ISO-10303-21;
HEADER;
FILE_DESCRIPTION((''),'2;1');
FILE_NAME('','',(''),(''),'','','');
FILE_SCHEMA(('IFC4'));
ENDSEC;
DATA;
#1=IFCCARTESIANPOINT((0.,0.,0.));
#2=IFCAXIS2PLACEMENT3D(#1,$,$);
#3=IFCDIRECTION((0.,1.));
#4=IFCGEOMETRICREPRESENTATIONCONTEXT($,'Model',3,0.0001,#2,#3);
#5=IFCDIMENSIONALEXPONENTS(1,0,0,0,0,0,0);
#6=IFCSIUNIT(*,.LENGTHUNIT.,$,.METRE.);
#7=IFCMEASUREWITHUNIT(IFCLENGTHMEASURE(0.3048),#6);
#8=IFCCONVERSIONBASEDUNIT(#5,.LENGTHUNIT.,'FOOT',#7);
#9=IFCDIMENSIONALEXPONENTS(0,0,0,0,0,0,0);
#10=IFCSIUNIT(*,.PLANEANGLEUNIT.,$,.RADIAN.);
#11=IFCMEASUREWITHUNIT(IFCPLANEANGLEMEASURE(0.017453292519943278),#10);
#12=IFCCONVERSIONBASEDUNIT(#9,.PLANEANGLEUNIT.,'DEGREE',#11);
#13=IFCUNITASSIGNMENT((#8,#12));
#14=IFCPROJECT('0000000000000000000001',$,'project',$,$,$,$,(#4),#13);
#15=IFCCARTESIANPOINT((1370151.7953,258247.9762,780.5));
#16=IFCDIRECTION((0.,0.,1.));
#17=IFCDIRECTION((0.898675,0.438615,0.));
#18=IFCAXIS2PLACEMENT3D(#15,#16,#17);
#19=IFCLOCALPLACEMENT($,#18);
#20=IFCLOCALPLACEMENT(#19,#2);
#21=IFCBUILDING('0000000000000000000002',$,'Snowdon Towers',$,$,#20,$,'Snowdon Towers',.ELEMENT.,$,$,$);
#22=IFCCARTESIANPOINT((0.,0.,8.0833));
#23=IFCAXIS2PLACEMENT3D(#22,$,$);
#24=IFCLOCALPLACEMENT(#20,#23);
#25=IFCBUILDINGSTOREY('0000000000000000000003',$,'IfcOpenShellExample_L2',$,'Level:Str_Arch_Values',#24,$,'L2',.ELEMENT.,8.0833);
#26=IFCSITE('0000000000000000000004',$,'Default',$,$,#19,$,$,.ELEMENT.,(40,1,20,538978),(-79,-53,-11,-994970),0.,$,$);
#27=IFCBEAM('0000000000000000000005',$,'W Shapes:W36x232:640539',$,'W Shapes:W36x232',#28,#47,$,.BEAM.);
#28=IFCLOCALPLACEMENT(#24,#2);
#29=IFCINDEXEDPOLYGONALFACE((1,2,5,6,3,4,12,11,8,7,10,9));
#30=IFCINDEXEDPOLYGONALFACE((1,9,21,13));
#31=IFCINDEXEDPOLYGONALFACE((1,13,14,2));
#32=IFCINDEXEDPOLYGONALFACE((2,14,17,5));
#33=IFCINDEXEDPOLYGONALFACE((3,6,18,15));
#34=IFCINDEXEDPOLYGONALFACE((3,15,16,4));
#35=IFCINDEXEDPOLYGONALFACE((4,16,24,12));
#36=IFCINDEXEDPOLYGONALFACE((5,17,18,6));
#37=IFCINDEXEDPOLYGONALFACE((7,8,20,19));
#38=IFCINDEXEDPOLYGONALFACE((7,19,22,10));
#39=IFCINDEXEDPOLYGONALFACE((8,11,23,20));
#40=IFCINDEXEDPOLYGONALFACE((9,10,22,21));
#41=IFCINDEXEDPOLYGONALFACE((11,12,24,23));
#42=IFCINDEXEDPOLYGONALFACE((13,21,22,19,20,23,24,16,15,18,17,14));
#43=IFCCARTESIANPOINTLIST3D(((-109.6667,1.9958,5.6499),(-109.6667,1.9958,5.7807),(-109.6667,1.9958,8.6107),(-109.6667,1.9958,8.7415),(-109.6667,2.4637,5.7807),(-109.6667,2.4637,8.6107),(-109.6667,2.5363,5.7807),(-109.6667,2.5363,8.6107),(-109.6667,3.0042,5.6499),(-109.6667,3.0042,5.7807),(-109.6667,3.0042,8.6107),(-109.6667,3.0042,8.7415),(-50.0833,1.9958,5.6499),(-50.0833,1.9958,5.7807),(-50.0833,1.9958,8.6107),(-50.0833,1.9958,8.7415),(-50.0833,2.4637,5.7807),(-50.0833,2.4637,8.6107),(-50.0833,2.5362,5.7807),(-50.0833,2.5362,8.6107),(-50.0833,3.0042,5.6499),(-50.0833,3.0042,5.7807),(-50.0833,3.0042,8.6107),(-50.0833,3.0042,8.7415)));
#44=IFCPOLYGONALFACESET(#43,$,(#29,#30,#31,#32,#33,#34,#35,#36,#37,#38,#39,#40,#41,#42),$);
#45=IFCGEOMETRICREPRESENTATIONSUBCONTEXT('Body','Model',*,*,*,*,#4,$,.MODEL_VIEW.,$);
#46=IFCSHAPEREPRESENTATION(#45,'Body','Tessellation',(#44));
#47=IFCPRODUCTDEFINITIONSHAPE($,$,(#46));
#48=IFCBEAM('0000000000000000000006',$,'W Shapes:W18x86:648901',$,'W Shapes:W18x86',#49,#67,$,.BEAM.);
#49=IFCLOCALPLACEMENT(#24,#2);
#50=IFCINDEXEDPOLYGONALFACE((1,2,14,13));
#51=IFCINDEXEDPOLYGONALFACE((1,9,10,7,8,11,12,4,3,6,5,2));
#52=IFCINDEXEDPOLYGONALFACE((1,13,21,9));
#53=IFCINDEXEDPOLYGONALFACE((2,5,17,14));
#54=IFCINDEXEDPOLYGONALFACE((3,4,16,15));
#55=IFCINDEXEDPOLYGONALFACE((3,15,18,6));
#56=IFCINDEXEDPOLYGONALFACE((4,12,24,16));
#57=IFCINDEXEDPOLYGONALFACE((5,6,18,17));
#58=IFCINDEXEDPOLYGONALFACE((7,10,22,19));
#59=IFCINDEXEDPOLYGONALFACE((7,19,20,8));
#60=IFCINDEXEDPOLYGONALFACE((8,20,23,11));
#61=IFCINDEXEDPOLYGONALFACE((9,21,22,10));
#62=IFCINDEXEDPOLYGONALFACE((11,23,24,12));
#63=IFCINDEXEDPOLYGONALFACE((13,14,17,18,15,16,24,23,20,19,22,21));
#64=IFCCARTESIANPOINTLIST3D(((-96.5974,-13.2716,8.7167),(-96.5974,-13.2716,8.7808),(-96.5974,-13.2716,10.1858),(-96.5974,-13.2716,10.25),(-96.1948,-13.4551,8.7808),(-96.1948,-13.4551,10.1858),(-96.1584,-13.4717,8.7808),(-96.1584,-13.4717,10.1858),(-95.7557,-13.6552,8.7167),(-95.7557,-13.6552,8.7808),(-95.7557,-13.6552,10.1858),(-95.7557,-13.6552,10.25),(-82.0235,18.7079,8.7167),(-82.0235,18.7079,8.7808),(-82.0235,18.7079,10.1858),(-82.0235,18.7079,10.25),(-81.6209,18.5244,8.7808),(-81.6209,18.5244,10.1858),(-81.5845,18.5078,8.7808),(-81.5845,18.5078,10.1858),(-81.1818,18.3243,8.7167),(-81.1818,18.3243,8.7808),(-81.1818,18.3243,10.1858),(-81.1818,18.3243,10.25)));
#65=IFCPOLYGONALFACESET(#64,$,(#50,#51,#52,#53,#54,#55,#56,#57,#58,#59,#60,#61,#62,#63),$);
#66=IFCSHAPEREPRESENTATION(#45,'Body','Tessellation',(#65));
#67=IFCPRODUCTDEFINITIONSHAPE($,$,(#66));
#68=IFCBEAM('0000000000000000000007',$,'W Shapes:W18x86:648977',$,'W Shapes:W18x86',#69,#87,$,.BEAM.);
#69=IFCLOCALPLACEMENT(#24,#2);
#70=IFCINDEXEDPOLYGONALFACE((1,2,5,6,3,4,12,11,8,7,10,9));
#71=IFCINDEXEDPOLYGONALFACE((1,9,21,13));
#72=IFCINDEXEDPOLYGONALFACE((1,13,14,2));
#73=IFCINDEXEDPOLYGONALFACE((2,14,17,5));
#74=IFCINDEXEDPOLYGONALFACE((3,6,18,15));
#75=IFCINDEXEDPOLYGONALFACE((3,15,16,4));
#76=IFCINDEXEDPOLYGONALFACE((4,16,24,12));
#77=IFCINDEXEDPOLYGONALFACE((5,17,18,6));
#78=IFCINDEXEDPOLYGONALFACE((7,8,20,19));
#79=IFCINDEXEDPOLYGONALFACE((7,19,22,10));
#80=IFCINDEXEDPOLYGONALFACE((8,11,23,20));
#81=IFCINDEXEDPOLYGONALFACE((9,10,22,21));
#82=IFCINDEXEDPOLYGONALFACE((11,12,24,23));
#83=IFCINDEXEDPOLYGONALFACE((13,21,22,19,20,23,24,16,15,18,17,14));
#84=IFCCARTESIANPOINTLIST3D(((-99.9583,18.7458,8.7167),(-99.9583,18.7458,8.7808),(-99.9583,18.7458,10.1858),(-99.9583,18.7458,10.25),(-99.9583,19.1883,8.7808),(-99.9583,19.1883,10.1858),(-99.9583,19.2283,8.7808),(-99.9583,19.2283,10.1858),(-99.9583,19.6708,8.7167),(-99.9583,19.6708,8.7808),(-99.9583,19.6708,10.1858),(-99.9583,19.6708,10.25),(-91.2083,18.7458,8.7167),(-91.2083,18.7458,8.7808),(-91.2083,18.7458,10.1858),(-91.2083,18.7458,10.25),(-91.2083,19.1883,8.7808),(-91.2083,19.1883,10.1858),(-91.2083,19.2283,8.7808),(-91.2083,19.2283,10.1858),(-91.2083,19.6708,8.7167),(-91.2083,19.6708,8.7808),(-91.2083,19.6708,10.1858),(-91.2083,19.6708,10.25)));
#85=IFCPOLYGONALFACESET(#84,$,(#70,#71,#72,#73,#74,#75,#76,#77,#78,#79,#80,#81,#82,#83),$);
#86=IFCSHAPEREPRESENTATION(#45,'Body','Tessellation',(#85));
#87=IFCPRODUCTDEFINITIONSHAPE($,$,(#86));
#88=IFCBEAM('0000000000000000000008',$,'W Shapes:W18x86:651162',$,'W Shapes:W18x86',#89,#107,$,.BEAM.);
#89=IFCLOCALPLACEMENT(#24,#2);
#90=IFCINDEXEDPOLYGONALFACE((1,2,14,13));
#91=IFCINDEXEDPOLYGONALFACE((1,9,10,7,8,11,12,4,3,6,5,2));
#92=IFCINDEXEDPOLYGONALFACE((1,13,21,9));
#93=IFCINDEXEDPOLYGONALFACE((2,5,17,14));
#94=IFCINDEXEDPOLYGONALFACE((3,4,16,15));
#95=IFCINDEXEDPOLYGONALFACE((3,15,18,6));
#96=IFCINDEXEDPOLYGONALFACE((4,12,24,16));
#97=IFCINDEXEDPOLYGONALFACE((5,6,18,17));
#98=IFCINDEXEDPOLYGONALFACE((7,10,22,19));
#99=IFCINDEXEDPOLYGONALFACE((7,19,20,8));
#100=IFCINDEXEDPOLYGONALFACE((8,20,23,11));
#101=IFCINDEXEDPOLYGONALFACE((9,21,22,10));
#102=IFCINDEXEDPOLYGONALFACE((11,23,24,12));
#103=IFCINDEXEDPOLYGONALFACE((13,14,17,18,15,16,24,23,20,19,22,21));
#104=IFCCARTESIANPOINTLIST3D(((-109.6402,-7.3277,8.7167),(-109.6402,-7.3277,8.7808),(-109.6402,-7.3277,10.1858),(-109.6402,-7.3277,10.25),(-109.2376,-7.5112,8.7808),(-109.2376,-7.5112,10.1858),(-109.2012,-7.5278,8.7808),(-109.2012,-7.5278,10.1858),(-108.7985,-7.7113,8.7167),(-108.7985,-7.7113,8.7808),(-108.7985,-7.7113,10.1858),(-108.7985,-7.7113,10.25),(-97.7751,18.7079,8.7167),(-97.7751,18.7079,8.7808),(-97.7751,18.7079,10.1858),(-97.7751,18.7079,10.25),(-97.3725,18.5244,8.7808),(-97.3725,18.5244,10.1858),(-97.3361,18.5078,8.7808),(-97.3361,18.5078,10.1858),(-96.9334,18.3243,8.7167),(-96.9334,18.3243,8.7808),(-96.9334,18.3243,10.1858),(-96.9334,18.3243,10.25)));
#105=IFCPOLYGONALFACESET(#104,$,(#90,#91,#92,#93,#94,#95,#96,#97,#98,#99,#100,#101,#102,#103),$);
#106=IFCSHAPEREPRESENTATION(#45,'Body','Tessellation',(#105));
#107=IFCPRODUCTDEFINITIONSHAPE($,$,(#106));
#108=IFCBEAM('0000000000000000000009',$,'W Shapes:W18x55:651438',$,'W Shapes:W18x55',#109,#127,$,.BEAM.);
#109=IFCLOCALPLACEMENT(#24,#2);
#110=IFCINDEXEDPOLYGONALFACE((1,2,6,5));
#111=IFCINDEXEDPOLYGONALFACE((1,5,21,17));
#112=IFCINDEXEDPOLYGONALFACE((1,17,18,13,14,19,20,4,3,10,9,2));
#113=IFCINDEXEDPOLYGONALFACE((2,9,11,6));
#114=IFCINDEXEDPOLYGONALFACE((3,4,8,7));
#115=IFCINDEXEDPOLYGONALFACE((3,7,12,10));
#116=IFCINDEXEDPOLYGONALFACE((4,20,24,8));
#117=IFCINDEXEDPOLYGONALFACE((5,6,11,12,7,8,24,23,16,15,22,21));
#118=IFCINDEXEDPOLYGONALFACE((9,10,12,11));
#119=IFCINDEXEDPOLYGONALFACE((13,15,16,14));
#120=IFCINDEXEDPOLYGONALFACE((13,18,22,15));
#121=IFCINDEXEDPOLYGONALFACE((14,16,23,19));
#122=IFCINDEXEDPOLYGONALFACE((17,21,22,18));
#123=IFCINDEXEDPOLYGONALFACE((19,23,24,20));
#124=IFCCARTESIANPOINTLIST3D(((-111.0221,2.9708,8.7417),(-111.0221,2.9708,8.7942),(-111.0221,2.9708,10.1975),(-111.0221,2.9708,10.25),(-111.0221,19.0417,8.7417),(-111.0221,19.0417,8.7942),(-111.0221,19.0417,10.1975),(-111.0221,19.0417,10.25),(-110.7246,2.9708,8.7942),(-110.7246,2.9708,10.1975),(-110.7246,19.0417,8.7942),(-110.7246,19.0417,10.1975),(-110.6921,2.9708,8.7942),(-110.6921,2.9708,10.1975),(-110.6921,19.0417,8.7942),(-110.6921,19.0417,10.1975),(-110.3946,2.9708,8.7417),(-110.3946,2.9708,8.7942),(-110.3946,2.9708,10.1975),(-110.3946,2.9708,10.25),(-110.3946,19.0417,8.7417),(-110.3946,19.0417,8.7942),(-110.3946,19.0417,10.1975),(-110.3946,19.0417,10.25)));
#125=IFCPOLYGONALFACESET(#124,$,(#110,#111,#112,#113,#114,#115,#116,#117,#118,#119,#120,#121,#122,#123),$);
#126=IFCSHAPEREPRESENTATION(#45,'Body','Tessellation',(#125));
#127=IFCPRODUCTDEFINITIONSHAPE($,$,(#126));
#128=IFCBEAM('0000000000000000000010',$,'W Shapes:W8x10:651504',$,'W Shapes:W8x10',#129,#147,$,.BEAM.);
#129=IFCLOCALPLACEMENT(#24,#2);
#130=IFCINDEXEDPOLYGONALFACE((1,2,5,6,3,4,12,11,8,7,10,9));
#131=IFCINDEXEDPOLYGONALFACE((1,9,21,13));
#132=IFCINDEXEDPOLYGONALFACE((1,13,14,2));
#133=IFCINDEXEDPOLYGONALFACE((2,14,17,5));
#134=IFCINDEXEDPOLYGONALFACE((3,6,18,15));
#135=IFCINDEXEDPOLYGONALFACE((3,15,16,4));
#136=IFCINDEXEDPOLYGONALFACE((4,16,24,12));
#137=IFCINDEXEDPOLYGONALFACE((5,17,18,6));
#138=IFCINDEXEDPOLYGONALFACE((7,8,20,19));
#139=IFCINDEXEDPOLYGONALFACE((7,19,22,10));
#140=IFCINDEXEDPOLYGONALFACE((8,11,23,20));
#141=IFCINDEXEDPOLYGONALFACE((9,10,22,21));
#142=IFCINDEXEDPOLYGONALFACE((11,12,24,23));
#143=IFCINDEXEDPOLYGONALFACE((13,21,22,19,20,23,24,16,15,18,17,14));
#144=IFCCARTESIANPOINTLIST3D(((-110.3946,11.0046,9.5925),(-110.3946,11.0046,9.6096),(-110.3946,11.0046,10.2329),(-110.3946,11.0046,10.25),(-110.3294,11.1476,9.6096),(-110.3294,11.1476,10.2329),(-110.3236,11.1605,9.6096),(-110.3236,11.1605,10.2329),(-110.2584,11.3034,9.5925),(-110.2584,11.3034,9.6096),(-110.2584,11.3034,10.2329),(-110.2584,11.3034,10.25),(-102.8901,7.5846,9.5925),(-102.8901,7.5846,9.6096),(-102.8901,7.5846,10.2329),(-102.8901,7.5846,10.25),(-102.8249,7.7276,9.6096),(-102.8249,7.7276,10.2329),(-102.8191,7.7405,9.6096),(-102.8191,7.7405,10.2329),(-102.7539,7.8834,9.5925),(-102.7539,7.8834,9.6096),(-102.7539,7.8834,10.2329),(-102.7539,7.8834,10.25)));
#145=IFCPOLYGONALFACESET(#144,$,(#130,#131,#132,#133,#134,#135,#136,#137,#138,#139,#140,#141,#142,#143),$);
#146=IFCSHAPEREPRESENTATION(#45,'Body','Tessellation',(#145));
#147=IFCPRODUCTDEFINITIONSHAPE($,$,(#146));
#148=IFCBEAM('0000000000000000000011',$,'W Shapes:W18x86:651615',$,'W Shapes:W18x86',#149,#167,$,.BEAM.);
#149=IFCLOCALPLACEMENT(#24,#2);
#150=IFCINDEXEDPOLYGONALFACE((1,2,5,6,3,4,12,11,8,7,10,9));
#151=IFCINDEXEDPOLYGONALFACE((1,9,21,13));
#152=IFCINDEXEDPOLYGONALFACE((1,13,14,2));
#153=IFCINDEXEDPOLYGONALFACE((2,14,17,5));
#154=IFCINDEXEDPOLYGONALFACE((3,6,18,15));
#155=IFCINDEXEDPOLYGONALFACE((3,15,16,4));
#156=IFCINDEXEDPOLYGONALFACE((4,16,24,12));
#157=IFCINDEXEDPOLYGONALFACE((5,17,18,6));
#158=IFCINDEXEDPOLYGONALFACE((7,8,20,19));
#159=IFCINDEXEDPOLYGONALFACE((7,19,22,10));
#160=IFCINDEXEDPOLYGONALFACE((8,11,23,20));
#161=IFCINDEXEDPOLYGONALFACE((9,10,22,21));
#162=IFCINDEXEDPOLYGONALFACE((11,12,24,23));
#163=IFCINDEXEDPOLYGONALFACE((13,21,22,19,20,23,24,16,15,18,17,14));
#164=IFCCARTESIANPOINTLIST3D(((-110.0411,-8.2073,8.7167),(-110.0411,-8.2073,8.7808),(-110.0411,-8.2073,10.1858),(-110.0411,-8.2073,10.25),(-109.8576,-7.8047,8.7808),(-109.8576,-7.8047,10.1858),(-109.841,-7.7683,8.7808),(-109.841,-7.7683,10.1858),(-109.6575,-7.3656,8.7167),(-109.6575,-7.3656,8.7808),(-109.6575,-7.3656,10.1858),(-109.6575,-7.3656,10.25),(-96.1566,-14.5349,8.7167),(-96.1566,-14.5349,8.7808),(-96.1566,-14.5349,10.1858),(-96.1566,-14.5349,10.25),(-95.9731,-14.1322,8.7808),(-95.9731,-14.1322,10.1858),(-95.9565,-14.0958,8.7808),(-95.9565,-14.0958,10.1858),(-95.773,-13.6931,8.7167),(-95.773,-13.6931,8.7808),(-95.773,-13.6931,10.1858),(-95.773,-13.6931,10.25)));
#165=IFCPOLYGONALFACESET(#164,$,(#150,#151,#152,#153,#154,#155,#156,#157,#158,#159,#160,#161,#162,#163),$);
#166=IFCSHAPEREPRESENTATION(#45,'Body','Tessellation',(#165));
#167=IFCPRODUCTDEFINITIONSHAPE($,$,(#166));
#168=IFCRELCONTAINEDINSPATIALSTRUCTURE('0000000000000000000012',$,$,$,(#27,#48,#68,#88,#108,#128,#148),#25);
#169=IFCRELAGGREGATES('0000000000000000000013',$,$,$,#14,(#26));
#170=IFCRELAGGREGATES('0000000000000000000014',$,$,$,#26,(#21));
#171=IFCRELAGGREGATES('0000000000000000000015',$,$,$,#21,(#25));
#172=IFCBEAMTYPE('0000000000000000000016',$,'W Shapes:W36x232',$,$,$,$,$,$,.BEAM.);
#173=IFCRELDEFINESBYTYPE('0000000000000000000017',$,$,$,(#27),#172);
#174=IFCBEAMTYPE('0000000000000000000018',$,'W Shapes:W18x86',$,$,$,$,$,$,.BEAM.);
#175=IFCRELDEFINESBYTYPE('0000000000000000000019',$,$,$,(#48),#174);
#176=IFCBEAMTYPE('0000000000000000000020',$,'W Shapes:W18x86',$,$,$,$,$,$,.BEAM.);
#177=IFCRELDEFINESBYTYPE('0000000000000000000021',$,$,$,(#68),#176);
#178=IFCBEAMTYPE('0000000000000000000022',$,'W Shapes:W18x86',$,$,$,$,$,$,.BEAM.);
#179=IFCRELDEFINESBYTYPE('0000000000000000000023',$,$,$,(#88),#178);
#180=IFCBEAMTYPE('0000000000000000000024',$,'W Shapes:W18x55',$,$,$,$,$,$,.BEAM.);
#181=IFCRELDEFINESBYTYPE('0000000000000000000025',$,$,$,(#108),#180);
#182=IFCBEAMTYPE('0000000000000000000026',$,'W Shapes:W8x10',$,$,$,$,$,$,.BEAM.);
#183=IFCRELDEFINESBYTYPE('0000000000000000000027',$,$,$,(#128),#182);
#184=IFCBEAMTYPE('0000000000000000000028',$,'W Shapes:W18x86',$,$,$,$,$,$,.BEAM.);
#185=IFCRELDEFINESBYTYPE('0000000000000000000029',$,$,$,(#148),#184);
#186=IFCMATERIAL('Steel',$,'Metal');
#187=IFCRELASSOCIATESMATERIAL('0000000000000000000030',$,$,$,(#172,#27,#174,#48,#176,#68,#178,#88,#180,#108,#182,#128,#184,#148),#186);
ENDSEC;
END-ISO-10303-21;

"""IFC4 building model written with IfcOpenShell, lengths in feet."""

from ifc_helpers import new_model, entity, si_unit, converted_unit, direction, frame, origin, place, context, subcontext, project, spatial, indexed_curve, outline, extrude, source, transform, mapped, material, type_object, type_shapes, element, save


model = new_model("IFC4")

# Units and contexts
model_context = context("Model", 3, precision=0.0001, world=origin(), true_north=direction((0.0, 1.0)))
body_context = subcontext(model_context, "Body", "Model", "MODEL_VIEW")
ifc_project = project(units=[converted_unit("LENGTHUNIT", "FOOT", entity("IfcLengthMeasure", 0.3048), si_unit("LENGTHUNIT", "METRE"), dimensions=[1, 0, 0, 0, 0, 0, 0]), converted_unit("PLANEANGLEUNIT", "DEGREE", entity("IfcPlaneAngleMeasure", 0.017453292519943278), si_unit("PLANEANGLEUNIT", "RADIAN"), dimensions=[0, 0, 0, 0, 0, 0, 0])], contexts=[model_context])

# Site, building, storey
site_placement = place(None, frame((1370151.7953, 258247.9762, 780.5), z_axis=(0.0, 0.0, 1.0), x_axis=(0.898675, 0.438615, 0.0)))
site = spatial("IfcSite", under=ifc_project, at=site_placement, Name="Default", CompositionType="ELEMENT", RefLatitude=(40, 1, 20, 538978), RefLongitude=(-79, -53, -11, -994970), RefElevation=0.0)
building_placement = place(site_placement, origin())
building = spatial("IfcBuilding", under=site, at=building_placement, Name="Snowdon Towers", LongName="Snowdon Towers", CompositionType="ELEMENT")
storey_placement = place(building_placement, frame((0.0, 0.0, 8.0833)))
storey = spatial("IfcBuildingStorey", under=building, at=storey_placement, Name="IfcOpenShellExample_L2", ObjectType="Level:Str_Arch_Values", LongName="L2", CompositionType="ELEMENT", Elevation=8.0833)

# Beams
ifc_material = material(Name="Steel", Category="Metal")
beam_type_1 = type_object("IfcBeamType", Name="W Shapes:W36x232", PredefinedType="BEAM", material=ifc_material)
shared_shape_1 = source(origin(), body_context, "Body", "SweptSolid", [
    extrude(outline(indexed_curve([(-0.5042, -1.415), (-0.5042, -1.5458), (0.5042, -1.5458), (0.5042, -1.415), (0.0362, -1.415), (0.0362, 1.415), (0.5042, 1.415), (0.5042, 1.5458), (-0.5042, 1.5458), (-0.5042, 1.415), (-0.0363, 1.415), (-0.0363, -1.415), (-0.5042, -1.415)], self_intersect=False)), frame((-29.5417, 0.0, 0.0), z_axis=(-1.0, 0.0, 0.0), x_axis=(0.0, -1.0, 0.0)), (0.0, 0.0, -1.0), 59.5833),
])
type_shapes(beam_type_1, [shared_shape_1])
beam_1_placement = place(storey_placement, frame((-80.125, 2.5, 7.1957)))
element("IfcBeam", 1, at=beam_1_placement, inside=storey, type_object=beam_type_1, material=ifc_material, Name="W Shapes:W36x232:640539", ObjectType="W Shapes:W36x232", PredefinedType="BEAM", context=body_context, shape_type="MappedRepresentation", body=[
    mapped(shared_shape_1, transform((0.0, 0.0, 0.0), scale=1.0)),
])
beam_type_2 = type_object("IfcBeamType", Name="W Shapes:W18x86", PredefinedType="BEAM", material=ifc_material)
shared_shape_2 = source(origin(), body_context, "Body", "SweptSolid", [
    extrude(outline(indexed_curve([(-0.4625, -0.7025), (-0.4625, -0.7667), (0.4625, -0.7667), (0.4625, -0.7025), (0.02, -0.7025), (0.02, 0.7025), (0.4625, 0.7025), (0.4625, 0.7667), (-0.4625, 0.7667), (-0.4625, 0.7025), (-0.02, 0.7025), (-0.02, -0.7025), (-0.4625, -0.7025)], self_intersect=False)), frame((-17.7002, 0.0, 0.0), z_axis=(-1.0, 0.0, 0.0), x_axis=(0.0, -1.0, 0.0)), (0.0, 0.0, -1.0), 35.1439),
])
type_shapes(beam_type_2, [shared_shape_2])
beam_2_placement = place(storey_placement, frame((-88.8364, 2.6431, 9.4833), z_axis=(0.0, 0.0, 1.0), x_axis=(0.414693, 0.909961, 0.0)))
element("IfcBeam", 2, at=beam_2_placement, inside=storey, type_object=beam_type_2, material=ifc_material, Name="W Shapes:W18x86:648901", ObjectType="W Shapes:W18x86", PredefinedType="BEAM", context=body_context, shape_type="MappedRepresentation", body=[
    mapped(shared_shape_2, transform((0.0, 0.0, 0.0), scale=1.0)),
])
beam_type_3 = type_object("IfcBeamType", Name="W Shapes:W18x86", PredefinedType="BEAM", material=ifc_material)
shared_shape_3 = source(origin(), body_context, "Body", "SweptSolid", [
    extrude(outline(indexed_curve([(-0.4625, -0.7025), (-0.4625, -0.7667), (0.4625, -0.7667), (0.4625, -0.7025), (0.02, -0.7025), (0.02, 0.7025), (0.4625, 0.7025), (0.4625, 0.7667), (-0.4625, 0.7667), (-0.4625, 0.7025), (-0.02, 0.7025), (-0.02, -0.7025), (-0.4625, -0.7025)], self_intersect=False)), frame((-4.6042, 0.0, 0.0), z_axis=(-1.0, 0.0, 0.0), x_axis=(0.0, -1.0, 0.0)), (0.0, 0.0, -1.0), 8.75),
])
type_shapes(beam_type_3, [shared_shape_3])
beam_3_placement = place(storey_placement, frame((-95.3542, 19.2083, 9.4833)))
element("IfcBeam", 3, at=beam_3_placement, inside=storey, type_object=beam_type_3, material=ifc_material, Name="W Shapes:W18x86:648977", ObjectType="W Shapes:W18x86", PredefinedType="BEAM", context=body_context, shape_type="MappedRepresentation", body=[
    mapped(shared_shape_3, transform((0.0, 0.0, 0.0), scale=1.0)),
])
beam_type_4 = type_object("IfcBeamType", Name="W Shapes:W18x86", PredefinedType="BEAM", material=ifc_material)
shared_shape_4 = source(origin(), body_context, "Body", "SweptSolid", [
    extrude(outline(indexed_curve([(-0.4625, -0.7025), (-0.4625, -0.7667), (0.4625, -0.7667), (0.4625, -0.7025), (0.02, -0.7025), (0.02, 0.7025), (0.4625, 0.7025), (0.4625, 0.7667), (-0.4625, 0.7667), (-0.4625, 0.7025), (-0.02, 0.7025), (-0.02, -0.7025), (-0.4625, -0.7025)], self_intersect=False)), frame((-14.4342, 0.0, 0.0), z_axis=(-1.0, 0.0, 0.0), x_axis=(0.0, -1.0, 0.0)), (0.0, 0.0, -1.0), 28.6118),
])
type_shapes(beam_type_4, [shared_shape_4])
beam_4_placement = place(storey_placement, frame((-103.2336, 5.615, 9.4833), z_axis=(0.0, 0.0, 1.0), x_axis=(0.414693, 0.909961, 0.0)))
element("IfcBeam", 4, at=beam_4_placement, inside=storey, type_object=beam_type_4, material=ifc_material, Name="W Shapes:W18x86:651162", ObjectType="W Shapes:W18x86", PredefinedType="BEAM", context=body_context, shape_type="MappedRepresentation", body=[
    mapped(shared_shape_4, transform((0.0, 0.0, 0.0), scale=1.0)),
])
beam_type_5 = type_object("IfcBeamType", Name="W Shapes:W18x55", PredefinedType="BEAM", material=ifc_material)
shared_shape_5 = source(origin(), body_context, "Body", "SweptSolid", [
    extrude(outline(indexed_curve([(-0.3138, -0.7017), (-0.3138, -0.7542), (0.3138, -0.7542), (0.3138, -0.7017), (0.0162, -0.7017), (0.0162, 0.7017), (0.3138, 0.7017), (0.3138, 0.7542), (-0.3137, 0.7542), (-0.3137, 0.7017), (-0.0163, 0.7017), (-0.0163, -0.7017), (-0.3138, -0.7017)], self_intersect=False)), frame((-7.8, 0.0, 0.0), z_axis=(-1.0, 0.0, 0.0), x_axis=(0.0, -1.0, 0.0)), (0.0, 0.0, -1.0), 16.0708),
])
type_shapes(beam_type_5, [shared_shape_5])
beam_5_placement = place(storey_placement, frame((-110.7083, 10.7708, 9.4958), z_axis=(0.0, 0.0, 1.0), x_axis=(0.0, 1.0, 0.0)))
element("IfcBeam", 5, at=beam_5_placement, inside=storey, type_object=beam_type_5, material=ifc_material, Name="W Shapes:W18x55:651438", ObjectType="W Shapes:W18x55", PredefinedType="BEAM", context=body_context, shape_type="MappedRepresentation", body=[
    mapped(shared_shape_5, transform((0.0, 0.0, 0.0), scale=1.0)),
])
beam_type_6 = type_object("IfcBeamType", Name="W Shapes:W8x10", PredefinedType="BEAM", material=ifc_material)
shared_shape_6 = source(origin(), body_context, "Body", "SweptSolid", [
    extrude(outline(indexed_curve([(-0.1642, -0.3117), (-0.1642, -0.3288), (0.1642, -0.3288), (0.1642, -0.3117), (0.0071, -0.3117), (0.0071, 0.3117), (0.1642, 0.3117), (0.1642, 0.3287), (-0.1642, 0.3287), (-0.1642, 0.3117), (-0.0071, 0.3117), (-0.0071, -0.3117), (-0.1642, -0.3117)], self_intersect=False)), frame((-4.1658, 0.0, 0.0), z_axis=(-1.0, 0.0, 0.0), x_axis=(0.0, -1.0, 0.0)), (0.0, 0.0, -1.0), 8.2471),
])
type_shapes(beam_type_6, [shared_shape_6])
beam_6_placement = place(storey_placement, frame((-106.5358, 9.4265, 9.9213), z_axis=(0.0, 0.0, 1.0), x_axis=(0.909961, -0.414693, 0.0)))
element("IfcBeam", 6, at=beam_6_placement, inside=storey, type_object=beam_type_6, material=ifc_material, Name="W Shapes:W8x10:651504", ObjectType="W Shapes:W8x10", PredefinedType="BEAM", context=body_context, shape_type="MappedRepresentation", body=[
    mapped(shared_shape_6, transform((0.0, 0.0, 0.0), scale=1.0)),
])
beam_type_7 = type_object("IfcBeamType", Name="W Shapes:W18x86", PredefinedType="BEAM", material=ifc_material)
shared_shape_7 = source(origin(), body_context, "Body", "SweptSolid", [
    extrude(outline(indexed_curve([(-0.4625, -0.7025), (-0.4625, -0.7667), (0.4625, -0.7667), (0.4625, -0.7025), (0.02, -0.7025), (0.02, 0.7025), (0.4625, 0.7025), (0.4625, 0.7667), (-0.4625, 0.7667), (-0.4625, 0.7025), (-0.02, 0.7025), (-0.02, -0.7025), (-0.4625, -0.7025)], self_intersect=False)), frame((-7.6292, 0.0, 0.0), z_axis=(-1.0, 0.0, 0.0), x_axis=(0.0, -1.0, 0.0)), (0.0, 0.0, -1.0), 15.2583),
])
type_shapes(beam_type_7, [shared_shape_7])
beam_7_placement = place(storey_placement, frame((-102.9071, -10.9502, 9.4833), z_axis=(0.0, 0.0, 1.0), x_axis=(0.909961, -0.414693, 0.0)))
element("IfcBeam", 7, at=beam_7_placement, inside=storey, type_object=beam_type_7, material=ifc_material, Name="W Shapes:W18x86:651615", ObjectType="W Shapes:W18x86", PredefinedType="BEAM", context=body_context, shape_type="MappedRepresentation", body=[
    mapped(shared_shape_7, transform((0.0, 0.0, 0.0), scale=1.0)),
])

save(model, "model.ifc")
